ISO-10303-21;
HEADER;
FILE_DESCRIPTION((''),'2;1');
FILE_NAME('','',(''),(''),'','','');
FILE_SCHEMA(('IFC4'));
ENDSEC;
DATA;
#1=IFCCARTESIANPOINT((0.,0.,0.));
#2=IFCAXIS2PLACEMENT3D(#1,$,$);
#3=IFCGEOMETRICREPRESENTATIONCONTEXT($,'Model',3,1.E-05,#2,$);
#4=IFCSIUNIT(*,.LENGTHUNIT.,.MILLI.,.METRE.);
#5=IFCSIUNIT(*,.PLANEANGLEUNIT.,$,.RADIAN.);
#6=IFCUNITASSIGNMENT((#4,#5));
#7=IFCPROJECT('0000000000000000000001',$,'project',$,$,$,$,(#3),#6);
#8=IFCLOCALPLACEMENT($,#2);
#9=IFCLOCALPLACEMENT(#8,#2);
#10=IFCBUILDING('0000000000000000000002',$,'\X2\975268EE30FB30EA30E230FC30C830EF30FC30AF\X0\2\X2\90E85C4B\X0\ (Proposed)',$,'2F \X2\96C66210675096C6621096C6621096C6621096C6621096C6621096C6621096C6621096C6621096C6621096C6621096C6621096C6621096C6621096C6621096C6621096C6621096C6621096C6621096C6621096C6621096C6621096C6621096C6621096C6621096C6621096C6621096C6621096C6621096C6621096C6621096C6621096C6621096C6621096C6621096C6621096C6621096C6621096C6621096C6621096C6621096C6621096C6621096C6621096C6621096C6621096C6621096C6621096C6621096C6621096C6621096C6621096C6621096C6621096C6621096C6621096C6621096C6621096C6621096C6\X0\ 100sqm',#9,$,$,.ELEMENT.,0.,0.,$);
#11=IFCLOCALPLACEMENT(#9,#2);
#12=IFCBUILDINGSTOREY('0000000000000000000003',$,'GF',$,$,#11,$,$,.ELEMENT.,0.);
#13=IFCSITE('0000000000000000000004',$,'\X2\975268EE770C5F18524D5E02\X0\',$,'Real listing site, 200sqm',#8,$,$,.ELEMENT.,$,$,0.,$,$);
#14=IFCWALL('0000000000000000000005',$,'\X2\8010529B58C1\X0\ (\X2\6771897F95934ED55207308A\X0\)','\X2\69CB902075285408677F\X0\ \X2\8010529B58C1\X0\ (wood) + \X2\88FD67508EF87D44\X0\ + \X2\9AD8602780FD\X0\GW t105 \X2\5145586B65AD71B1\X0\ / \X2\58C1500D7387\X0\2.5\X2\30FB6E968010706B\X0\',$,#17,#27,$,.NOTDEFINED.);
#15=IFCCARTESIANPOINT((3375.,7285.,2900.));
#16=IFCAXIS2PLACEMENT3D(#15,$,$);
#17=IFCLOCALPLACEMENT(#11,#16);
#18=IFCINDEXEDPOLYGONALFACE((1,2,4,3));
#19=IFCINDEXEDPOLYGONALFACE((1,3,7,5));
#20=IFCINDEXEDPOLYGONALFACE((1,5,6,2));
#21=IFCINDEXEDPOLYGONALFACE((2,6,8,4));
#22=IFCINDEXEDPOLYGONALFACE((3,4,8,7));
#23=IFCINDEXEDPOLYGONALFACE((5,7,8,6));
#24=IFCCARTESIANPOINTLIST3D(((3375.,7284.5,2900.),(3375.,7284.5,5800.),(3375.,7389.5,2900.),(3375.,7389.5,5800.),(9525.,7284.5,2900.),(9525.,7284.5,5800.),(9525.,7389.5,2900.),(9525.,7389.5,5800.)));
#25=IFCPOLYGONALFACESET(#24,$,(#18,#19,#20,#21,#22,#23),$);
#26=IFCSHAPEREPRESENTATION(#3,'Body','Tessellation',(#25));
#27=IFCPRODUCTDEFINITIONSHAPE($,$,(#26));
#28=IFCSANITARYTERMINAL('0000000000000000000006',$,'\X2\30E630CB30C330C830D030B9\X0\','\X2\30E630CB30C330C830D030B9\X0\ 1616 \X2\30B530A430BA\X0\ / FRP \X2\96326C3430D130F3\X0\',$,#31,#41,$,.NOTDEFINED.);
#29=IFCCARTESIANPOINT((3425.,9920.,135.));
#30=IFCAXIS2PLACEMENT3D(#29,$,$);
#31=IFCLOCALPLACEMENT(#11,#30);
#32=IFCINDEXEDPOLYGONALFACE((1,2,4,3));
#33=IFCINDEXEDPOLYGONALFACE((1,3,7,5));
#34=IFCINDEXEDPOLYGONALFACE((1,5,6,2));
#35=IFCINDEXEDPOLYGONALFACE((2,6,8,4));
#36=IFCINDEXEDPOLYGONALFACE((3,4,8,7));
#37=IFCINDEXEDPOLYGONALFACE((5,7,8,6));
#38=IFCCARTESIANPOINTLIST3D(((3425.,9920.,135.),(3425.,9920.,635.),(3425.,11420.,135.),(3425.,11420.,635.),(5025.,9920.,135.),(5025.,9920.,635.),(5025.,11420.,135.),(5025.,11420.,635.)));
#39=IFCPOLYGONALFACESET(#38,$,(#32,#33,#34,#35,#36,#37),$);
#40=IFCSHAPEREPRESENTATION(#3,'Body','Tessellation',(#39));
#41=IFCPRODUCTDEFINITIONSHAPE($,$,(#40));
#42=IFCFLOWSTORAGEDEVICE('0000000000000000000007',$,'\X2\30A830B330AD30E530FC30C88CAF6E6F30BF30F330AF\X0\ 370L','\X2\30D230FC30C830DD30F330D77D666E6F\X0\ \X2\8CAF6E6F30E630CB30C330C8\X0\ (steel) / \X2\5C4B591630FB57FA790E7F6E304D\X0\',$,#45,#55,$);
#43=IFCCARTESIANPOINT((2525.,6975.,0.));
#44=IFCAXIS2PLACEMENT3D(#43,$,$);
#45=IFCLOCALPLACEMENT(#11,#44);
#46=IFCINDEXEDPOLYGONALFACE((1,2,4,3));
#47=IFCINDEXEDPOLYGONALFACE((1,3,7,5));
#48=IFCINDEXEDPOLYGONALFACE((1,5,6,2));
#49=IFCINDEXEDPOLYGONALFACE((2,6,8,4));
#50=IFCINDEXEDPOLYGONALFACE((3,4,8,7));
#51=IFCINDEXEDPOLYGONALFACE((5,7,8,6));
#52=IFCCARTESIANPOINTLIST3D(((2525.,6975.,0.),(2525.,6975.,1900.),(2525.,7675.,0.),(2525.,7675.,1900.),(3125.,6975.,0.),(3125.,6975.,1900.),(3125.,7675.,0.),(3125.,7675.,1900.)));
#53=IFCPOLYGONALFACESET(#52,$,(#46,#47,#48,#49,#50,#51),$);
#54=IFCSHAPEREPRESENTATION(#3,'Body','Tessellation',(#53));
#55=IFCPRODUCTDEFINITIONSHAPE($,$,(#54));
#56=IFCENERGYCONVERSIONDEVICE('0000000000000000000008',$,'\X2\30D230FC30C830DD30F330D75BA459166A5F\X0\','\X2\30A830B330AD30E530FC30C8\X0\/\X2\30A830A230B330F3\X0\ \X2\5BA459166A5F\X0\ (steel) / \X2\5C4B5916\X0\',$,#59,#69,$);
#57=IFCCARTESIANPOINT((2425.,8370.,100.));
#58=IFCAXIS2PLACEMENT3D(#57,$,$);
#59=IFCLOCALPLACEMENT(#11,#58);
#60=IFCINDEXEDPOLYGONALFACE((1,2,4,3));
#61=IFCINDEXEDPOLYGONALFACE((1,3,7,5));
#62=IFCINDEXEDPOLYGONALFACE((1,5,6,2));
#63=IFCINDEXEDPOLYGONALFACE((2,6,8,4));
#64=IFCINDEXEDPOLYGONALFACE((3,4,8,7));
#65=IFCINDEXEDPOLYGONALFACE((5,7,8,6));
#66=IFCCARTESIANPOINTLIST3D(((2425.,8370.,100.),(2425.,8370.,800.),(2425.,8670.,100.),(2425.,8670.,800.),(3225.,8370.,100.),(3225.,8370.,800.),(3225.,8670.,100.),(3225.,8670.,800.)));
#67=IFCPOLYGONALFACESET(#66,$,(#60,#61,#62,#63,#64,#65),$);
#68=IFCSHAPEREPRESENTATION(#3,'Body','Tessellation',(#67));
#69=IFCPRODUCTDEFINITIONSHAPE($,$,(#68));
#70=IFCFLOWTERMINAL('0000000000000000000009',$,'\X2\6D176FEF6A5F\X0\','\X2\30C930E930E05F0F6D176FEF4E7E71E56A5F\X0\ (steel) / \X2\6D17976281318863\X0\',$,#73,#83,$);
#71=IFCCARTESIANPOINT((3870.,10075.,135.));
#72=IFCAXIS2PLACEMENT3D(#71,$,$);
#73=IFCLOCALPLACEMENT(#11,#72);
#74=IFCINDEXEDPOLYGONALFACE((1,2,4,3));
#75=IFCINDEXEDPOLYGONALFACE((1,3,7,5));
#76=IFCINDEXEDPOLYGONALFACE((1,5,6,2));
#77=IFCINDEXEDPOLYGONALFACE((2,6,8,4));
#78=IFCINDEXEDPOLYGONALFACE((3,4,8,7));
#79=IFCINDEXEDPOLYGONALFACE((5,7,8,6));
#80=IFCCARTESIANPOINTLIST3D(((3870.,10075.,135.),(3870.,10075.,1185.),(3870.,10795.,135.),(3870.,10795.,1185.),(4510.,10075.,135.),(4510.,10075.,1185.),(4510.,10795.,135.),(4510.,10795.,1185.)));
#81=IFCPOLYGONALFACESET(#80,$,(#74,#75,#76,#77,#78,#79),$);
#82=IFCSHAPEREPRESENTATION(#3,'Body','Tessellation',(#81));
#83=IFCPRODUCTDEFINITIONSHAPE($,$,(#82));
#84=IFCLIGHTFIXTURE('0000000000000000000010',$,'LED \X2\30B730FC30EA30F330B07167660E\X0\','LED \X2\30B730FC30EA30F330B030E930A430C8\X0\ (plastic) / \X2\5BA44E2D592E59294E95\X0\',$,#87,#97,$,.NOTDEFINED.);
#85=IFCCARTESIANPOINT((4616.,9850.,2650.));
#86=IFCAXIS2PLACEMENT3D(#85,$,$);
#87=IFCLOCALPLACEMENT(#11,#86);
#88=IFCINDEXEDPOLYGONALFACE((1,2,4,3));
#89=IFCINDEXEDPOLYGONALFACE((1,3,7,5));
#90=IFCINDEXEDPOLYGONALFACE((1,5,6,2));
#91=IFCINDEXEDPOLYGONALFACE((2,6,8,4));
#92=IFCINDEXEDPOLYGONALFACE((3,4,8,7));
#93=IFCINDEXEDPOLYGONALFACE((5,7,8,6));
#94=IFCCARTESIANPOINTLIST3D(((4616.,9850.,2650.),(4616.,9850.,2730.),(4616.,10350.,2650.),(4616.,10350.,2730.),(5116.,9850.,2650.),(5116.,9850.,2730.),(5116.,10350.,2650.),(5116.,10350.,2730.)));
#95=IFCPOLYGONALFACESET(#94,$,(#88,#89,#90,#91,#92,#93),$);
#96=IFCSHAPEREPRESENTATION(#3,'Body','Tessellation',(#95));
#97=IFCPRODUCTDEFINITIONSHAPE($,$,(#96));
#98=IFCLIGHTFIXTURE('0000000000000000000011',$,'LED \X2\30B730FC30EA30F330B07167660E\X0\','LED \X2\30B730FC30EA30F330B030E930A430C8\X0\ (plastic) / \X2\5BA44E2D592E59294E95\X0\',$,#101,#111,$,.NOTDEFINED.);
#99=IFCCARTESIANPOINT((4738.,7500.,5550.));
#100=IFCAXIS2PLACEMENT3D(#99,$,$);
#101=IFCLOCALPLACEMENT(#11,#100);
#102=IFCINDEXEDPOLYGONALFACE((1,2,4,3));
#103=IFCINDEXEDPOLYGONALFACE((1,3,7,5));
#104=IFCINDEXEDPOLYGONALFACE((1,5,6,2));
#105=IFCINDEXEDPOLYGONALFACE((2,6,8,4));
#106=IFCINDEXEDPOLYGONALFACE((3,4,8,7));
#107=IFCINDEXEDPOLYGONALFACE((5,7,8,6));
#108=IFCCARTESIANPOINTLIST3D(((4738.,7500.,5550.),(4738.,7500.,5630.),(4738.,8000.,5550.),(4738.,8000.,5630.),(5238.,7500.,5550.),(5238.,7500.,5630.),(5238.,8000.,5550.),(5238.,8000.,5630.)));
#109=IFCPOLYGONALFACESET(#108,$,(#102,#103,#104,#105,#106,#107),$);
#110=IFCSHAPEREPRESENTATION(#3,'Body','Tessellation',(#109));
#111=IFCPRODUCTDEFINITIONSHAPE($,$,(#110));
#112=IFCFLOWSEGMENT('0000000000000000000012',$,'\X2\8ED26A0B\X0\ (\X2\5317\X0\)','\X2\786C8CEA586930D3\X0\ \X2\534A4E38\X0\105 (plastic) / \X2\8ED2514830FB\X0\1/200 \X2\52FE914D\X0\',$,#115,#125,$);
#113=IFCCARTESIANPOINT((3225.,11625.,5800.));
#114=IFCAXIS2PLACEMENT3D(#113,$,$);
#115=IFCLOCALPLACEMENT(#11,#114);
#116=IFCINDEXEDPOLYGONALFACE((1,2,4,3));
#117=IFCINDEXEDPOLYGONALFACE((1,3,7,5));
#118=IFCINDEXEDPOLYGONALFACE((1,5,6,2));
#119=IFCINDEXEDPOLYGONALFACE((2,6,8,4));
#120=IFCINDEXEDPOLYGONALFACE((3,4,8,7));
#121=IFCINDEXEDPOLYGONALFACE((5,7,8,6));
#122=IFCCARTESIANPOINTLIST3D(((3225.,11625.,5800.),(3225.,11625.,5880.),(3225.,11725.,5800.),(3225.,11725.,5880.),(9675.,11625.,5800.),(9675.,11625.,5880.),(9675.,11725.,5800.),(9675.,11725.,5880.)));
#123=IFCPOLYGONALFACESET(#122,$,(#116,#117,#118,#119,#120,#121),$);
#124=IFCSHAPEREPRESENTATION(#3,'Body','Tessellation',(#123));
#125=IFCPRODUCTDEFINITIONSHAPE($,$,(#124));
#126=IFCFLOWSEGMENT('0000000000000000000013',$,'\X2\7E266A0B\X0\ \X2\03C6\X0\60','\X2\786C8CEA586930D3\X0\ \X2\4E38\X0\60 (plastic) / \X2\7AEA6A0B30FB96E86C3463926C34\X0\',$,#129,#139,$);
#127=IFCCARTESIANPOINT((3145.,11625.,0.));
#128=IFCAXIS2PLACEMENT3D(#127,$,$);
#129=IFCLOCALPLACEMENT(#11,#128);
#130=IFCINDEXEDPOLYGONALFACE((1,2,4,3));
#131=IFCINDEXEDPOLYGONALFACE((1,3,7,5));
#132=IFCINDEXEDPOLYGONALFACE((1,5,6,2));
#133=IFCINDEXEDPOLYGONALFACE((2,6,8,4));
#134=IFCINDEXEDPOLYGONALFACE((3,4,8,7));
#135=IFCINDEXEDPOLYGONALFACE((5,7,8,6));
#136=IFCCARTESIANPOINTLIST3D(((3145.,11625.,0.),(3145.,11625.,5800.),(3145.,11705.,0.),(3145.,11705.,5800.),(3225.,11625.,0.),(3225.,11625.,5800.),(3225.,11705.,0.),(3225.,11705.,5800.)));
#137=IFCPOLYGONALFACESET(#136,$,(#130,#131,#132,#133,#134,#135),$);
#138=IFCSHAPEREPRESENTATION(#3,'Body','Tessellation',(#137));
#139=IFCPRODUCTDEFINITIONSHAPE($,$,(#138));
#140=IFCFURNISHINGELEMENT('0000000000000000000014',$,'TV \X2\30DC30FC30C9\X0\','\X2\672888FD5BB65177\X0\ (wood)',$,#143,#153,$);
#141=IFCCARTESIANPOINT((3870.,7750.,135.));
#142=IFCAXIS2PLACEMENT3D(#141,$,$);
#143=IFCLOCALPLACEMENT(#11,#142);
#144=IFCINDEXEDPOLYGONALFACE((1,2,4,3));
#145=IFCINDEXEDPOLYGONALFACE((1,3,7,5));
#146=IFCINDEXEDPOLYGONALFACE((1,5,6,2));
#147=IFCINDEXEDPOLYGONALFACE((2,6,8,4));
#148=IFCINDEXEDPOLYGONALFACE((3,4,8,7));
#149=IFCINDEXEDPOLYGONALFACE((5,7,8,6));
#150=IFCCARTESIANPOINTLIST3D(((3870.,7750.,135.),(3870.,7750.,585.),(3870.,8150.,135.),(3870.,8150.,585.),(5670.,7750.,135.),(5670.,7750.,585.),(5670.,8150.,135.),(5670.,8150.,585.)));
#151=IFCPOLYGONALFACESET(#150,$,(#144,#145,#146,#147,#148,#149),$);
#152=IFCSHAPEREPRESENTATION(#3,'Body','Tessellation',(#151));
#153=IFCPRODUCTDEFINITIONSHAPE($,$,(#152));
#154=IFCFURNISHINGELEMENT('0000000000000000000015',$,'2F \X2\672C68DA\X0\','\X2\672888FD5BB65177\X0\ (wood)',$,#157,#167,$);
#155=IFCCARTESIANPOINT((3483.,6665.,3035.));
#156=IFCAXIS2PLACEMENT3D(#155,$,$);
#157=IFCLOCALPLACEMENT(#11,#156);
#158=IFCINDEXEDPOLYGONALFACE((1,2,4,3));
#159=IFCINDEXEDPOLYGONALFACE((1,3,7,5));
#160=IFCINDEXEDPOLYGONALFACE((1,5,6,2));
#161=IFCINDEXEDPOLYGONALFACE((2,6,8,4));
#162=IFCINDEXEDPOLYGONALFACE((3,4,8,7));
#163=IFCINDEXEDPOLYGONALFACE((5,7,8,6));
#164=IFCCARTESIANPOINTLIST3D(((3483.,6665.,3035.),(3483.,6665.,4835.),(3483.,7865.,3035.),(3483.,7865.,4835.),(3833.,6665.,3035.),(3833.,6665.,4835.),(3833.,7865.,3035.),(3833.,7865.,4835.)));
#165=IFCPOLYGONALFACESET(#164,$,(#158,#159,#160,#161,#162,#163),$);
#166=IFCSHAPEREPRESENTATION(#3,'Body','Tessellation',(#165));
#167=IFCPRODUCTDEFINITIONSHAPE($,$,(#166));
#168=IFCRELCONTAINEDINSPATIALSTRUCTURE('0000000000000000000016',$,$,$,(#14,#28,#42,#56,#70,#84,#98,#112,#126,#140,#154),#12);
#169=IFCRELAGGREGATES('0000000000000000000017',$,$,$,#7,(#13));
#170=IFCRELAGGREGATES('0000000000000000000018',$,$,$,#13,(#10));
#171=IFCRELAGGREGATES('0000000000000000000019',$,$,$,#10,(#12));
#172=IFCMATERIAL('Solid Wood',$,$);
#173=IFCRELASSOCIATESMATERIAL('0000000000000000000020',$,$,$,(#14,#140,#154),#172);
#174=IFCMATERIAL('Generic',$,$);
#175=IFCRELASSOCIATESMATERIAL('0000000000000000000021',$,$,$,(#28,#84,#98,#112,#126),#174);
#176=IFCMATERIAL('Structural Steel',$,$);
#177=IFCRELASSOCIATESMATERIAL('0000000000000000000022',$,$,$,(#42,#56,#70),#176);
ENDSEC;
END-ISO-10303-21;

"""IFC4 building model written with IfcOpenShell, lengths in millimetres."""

from ifc_helpers import new_model, si_unit, frame, frame_2d, origin, place, context, project, spatial, rectangle, extrude, material, element, save


model = new_model("IFC4")

# Units and contexts
model_context = context("Model", 3, precision=1e-05, world=origin())
ifc_project = project(units=[si_unit("LENGTHUNIT", "METRE", prefix="MILLI"), si_unit("PLANEANGLEUNIT", "RADIAN")], contexts=[model_context])

# Site, building, storey
site_placement = place(None, origin())
site = spatial("IfcSite", under=ifc_project, at=site_placement, Name="青森県弘前市", ObjectType="Real listing site, 200sqm", CompositionType="ELEMENT", RefElevation=0.0)
building_placement = place(site_placement, origin())
building = spatial("IfcBuilding", under=site, at=building_placement, Name="青森・リモートワーク2部屋 (Proposed)", ObjectType="2F 集成材集成集成集成集成集成集成集成集成集成集成集成集成集成集成集成集成集成集成集成集成集成集成集成集成集成集成集成集成集成集成集成集成集成集成集成集成集成集成集成集成集成集成集成集成集成集成集成集成集成集成集成集成集成集成集成集成集成集成集 100sqm", CompositionType="ELEMENT", ElevationOfRefHeight=0.0, ElevationOfTerrain=0.0)
storey_placement = place(building_placement, origin())
storey = spatial("IfcBuildingStorey", under=building, at=storey_placement, Name="GF", CompositionType="ELEMENT", Elevation=0.0)

# Shared definitions
ifc_material_1 = material(Name="Solid Wood")

# Wall
wall_1_placement = place(storey_placement, frame((3375.0, 7285.0, 2900.0)))
element("IfcWall", 1, at=wall_1_placement, inside=storey, material=ifc_material_1, Name="耐力壁 (東西間仕切り)", Description="構造用合板 耐力壁 (wood) + 製材軸組 + 高性能GW t105 充填断熱 / 壁倍率2.5・準耐火", PredefinedType="NOTDEFINED", context=model_context, shape_type="SweptSolid", body=[
    extrude(rectangle(XDim=6150.0, YDim=105.0, at=frame_2d((3075.0, 52.0))), frame((3375.0, 7285.0, 2900.0)), (0.0, 0.0, 1.0), 2900.0),
])

# Sanitary terminal
ifc_material_2 = material(Name="Generic")
sanitary_terminal_placement = place(storey_placement, frame((3425.0, 9920.0, 135.0)))
element("IfcSanitaryTerminal", 2, at=sanitary_terminal_placement, inside=storey, material=ifc_material_2, Name="ユニットバス", Description="ユニットバス 1616 サイズ / FRP 防水パン", PredefinedType="NOTDEFINED", context=model_context, shape_type="SweptSolid", body=[
    extrude(rectangle(XDim=1600.0, YDim=1500.0, at=frame_2d((800.0, 750.0))), frame((3425.0, 9920.0, 135.0)), (0.0, 0.0, 1.0), 500.0),
])

# Flow storage device
ifc_material_3 = material(Name="Structural Steel")
flow_storage_device_placement = place(storey_placement, frame((2525.0, 6975.0, 0.0)))
element("IfcFlowStorageDevice", 3, at=flow_storage_device_placement, inside=storey, material=ifc_material_3, Name="エコキュート貯湯タンク 370L", Description="ヒートポンプ給湯 貯湯ユニット (steel) / 屋外・基礎置き", context=model_context, shape_type="SweptSolid", body=[
    extrude(rectangle(XDim=600.0, YDim=700.0, at=frame_2d((300.0, 350.0))), frame((2525.0, 6975.0, 0.0)), (0.0, 0.0, 1.0), 1900.0),
])

# Energy conversion device
energy_conversion_device_placement = place(storey_placement, frame((2425.0, 8370.0, 100.0)))
element("IfcEnergyConversionDevice", 4, at=energy_conversion_device_placement, inside=storey, material=ifc_material_3, Name="ヒートポンプ室外機", Description="エコキュート/エアコン 室外機 (steel) / 屋外", context=model_context, shape_type="SweptSolid", body=[
    extrude(rectangle(XDim=800.0, YDim=300.0, at=frame_2d((400.0, 150.0))), frame((2425.0, 8370.0, 100.0)), (0.0, 0.0, 1.0), 700.0),
])

# Flow terminal
flow_terminal_placement = place(storey_placement, frame((3870.0, 10075.0, 135.0)))
element("IfcFlowTerminal", 5, at=flow_terminal_placement, inside=storey, material=ifc_material_3, Name="洗濯機", Description="ドラム式洗濯乾燥機 (steel) / 洗面脱衣", context=model_context, shape_type="SweptSolid", body=[
    extrude(rectangle(XDim=640.0, YDim=720.0, at=frame_2d((320.0, 360.0))), frame((3870.0, 10075.0, 135.0)), (0.0, 0.0, 1.0), 1050.0),
])

# Light fixtures
light_fixture_1_placement = place(storey_placement, frame((4616.0, 9850.0, 2650.0)))
element("IfcLightFixture", 6, at=light_fixture_1_placement, inside=storey, material=ifc_material_2, Name="LED シーリング照明", Description="LED シーリングライト (plastic) / 室中央天井", PredefinedType="NOTDEFINED", context=model_context, shape_type="SweptSolid", body=[
    extrude(rectangle(XDim=500.0, YDim=500.0, at=frame_2d((250.0, 250.0))), frame((4616.0, 9850.0, 2650.0)), (0.0, 0.0, 1.0), 80.0),
])
light_fixture_2_placement = place(storey_placement, frame((4738.0, 7500.0, 5550.0)))
element("IfcLightFixture", 7, at=light_fixture_2_placement, inside=storey, material=ifc_material_2, Name="LED シーリング照明", Description="LED シーリングライト (plastic) / 室中央天井", PredefinedType="NOTDEFINED", context=model_context, shape_type="SweptSolid", body=[
    extrude(rectangle(XDim=500.0, YDim=500.0, at=frame_2d((250.0, 250.0))), frame((4738.0, 7500.0, 5550.0)), (0.0, 0.0, 1.0), 80.0),
])

# Flow segments
flow_segment_1_placement = place(storey_placement, frame((3225.0, 11625.0, 5800.0)))
element("IfcFlowSegment", 8, at=flow_segment_1_placement, inside=storey, material=ifc_material_2, Name="軒樋 (北)", Description="硬質塩ビ 半丸105 (plastic) / 軒先・1/200 勾配", context=model_context, shape_type="SweptSolid", body=[
    extrude(rectangle(XDim=6450.0, YDim=100.0, at=frame_2d((3225.0, 50.0))), frame((3225.0, 11625.0, 5800.0)), (0.0, 0.0, 1.0), 80.0),
])
flow_segment_2_placement = place(storey_placement, frame((3145.0, 11625.0, 0.0)))
element("IfcFlowSegment", 9, at=flow_segment_2_placement, inside=storey, material=ifc_material_2, Name="縦樋 φ60", Description="硬質塩ビ 丸60 (plastic) / 竪樋・雨水排水", context=model_context, shape_type="SweptSolid", body=[
    extrude(rectangle(XDim=80.0, YDim=80.0, at=frame_2d((40.0, 40.0))), frame((3145.0, 11625.0, 0.0)), (0.0, 0.0, 1.0), 5800.0),
])

# Furnishing elements
furnishing_1_placement = place(storey_placement, frame((3870.0, 7750.0, 135.0)))
element("IfcFurnishingElement", 10, at=furnishing_1_placement, inside=storey, material=ifc_material_1, Name="TV ボード", Description="木製家具 (wood)", context=model_context, shape_type="SweptSolid", body=[
    extrude(rectangle(XDim=1800.0, YDim=400.0, at=frame_2d((900.0, 200.0))), frame((3870.0, 7750.0, 135.0)), (0.0, 0.0, 1.0), 450.0),
])
furnishing_2_placement = place(storey_placement, frame((3483.0, 6665.0, 3035.0)))
element("IfcFurnishingElement", 11, at=furnishing_2_placement, inside=storey, material=ifc_material_1, Name="2F 本棚", Description="木製家具 (wood)", context=model_context, shape_type="SweptSolid", body=[
    extrude(rectangle(XDim=350.0, YDim=1200.0, at=frame_2d((175.0, 600.0))), frame((3483.0, 6665.0, 3035.0)), (0.0, 0.0, 1.0), 1800.0),
])

save(model, "model.ifc")
